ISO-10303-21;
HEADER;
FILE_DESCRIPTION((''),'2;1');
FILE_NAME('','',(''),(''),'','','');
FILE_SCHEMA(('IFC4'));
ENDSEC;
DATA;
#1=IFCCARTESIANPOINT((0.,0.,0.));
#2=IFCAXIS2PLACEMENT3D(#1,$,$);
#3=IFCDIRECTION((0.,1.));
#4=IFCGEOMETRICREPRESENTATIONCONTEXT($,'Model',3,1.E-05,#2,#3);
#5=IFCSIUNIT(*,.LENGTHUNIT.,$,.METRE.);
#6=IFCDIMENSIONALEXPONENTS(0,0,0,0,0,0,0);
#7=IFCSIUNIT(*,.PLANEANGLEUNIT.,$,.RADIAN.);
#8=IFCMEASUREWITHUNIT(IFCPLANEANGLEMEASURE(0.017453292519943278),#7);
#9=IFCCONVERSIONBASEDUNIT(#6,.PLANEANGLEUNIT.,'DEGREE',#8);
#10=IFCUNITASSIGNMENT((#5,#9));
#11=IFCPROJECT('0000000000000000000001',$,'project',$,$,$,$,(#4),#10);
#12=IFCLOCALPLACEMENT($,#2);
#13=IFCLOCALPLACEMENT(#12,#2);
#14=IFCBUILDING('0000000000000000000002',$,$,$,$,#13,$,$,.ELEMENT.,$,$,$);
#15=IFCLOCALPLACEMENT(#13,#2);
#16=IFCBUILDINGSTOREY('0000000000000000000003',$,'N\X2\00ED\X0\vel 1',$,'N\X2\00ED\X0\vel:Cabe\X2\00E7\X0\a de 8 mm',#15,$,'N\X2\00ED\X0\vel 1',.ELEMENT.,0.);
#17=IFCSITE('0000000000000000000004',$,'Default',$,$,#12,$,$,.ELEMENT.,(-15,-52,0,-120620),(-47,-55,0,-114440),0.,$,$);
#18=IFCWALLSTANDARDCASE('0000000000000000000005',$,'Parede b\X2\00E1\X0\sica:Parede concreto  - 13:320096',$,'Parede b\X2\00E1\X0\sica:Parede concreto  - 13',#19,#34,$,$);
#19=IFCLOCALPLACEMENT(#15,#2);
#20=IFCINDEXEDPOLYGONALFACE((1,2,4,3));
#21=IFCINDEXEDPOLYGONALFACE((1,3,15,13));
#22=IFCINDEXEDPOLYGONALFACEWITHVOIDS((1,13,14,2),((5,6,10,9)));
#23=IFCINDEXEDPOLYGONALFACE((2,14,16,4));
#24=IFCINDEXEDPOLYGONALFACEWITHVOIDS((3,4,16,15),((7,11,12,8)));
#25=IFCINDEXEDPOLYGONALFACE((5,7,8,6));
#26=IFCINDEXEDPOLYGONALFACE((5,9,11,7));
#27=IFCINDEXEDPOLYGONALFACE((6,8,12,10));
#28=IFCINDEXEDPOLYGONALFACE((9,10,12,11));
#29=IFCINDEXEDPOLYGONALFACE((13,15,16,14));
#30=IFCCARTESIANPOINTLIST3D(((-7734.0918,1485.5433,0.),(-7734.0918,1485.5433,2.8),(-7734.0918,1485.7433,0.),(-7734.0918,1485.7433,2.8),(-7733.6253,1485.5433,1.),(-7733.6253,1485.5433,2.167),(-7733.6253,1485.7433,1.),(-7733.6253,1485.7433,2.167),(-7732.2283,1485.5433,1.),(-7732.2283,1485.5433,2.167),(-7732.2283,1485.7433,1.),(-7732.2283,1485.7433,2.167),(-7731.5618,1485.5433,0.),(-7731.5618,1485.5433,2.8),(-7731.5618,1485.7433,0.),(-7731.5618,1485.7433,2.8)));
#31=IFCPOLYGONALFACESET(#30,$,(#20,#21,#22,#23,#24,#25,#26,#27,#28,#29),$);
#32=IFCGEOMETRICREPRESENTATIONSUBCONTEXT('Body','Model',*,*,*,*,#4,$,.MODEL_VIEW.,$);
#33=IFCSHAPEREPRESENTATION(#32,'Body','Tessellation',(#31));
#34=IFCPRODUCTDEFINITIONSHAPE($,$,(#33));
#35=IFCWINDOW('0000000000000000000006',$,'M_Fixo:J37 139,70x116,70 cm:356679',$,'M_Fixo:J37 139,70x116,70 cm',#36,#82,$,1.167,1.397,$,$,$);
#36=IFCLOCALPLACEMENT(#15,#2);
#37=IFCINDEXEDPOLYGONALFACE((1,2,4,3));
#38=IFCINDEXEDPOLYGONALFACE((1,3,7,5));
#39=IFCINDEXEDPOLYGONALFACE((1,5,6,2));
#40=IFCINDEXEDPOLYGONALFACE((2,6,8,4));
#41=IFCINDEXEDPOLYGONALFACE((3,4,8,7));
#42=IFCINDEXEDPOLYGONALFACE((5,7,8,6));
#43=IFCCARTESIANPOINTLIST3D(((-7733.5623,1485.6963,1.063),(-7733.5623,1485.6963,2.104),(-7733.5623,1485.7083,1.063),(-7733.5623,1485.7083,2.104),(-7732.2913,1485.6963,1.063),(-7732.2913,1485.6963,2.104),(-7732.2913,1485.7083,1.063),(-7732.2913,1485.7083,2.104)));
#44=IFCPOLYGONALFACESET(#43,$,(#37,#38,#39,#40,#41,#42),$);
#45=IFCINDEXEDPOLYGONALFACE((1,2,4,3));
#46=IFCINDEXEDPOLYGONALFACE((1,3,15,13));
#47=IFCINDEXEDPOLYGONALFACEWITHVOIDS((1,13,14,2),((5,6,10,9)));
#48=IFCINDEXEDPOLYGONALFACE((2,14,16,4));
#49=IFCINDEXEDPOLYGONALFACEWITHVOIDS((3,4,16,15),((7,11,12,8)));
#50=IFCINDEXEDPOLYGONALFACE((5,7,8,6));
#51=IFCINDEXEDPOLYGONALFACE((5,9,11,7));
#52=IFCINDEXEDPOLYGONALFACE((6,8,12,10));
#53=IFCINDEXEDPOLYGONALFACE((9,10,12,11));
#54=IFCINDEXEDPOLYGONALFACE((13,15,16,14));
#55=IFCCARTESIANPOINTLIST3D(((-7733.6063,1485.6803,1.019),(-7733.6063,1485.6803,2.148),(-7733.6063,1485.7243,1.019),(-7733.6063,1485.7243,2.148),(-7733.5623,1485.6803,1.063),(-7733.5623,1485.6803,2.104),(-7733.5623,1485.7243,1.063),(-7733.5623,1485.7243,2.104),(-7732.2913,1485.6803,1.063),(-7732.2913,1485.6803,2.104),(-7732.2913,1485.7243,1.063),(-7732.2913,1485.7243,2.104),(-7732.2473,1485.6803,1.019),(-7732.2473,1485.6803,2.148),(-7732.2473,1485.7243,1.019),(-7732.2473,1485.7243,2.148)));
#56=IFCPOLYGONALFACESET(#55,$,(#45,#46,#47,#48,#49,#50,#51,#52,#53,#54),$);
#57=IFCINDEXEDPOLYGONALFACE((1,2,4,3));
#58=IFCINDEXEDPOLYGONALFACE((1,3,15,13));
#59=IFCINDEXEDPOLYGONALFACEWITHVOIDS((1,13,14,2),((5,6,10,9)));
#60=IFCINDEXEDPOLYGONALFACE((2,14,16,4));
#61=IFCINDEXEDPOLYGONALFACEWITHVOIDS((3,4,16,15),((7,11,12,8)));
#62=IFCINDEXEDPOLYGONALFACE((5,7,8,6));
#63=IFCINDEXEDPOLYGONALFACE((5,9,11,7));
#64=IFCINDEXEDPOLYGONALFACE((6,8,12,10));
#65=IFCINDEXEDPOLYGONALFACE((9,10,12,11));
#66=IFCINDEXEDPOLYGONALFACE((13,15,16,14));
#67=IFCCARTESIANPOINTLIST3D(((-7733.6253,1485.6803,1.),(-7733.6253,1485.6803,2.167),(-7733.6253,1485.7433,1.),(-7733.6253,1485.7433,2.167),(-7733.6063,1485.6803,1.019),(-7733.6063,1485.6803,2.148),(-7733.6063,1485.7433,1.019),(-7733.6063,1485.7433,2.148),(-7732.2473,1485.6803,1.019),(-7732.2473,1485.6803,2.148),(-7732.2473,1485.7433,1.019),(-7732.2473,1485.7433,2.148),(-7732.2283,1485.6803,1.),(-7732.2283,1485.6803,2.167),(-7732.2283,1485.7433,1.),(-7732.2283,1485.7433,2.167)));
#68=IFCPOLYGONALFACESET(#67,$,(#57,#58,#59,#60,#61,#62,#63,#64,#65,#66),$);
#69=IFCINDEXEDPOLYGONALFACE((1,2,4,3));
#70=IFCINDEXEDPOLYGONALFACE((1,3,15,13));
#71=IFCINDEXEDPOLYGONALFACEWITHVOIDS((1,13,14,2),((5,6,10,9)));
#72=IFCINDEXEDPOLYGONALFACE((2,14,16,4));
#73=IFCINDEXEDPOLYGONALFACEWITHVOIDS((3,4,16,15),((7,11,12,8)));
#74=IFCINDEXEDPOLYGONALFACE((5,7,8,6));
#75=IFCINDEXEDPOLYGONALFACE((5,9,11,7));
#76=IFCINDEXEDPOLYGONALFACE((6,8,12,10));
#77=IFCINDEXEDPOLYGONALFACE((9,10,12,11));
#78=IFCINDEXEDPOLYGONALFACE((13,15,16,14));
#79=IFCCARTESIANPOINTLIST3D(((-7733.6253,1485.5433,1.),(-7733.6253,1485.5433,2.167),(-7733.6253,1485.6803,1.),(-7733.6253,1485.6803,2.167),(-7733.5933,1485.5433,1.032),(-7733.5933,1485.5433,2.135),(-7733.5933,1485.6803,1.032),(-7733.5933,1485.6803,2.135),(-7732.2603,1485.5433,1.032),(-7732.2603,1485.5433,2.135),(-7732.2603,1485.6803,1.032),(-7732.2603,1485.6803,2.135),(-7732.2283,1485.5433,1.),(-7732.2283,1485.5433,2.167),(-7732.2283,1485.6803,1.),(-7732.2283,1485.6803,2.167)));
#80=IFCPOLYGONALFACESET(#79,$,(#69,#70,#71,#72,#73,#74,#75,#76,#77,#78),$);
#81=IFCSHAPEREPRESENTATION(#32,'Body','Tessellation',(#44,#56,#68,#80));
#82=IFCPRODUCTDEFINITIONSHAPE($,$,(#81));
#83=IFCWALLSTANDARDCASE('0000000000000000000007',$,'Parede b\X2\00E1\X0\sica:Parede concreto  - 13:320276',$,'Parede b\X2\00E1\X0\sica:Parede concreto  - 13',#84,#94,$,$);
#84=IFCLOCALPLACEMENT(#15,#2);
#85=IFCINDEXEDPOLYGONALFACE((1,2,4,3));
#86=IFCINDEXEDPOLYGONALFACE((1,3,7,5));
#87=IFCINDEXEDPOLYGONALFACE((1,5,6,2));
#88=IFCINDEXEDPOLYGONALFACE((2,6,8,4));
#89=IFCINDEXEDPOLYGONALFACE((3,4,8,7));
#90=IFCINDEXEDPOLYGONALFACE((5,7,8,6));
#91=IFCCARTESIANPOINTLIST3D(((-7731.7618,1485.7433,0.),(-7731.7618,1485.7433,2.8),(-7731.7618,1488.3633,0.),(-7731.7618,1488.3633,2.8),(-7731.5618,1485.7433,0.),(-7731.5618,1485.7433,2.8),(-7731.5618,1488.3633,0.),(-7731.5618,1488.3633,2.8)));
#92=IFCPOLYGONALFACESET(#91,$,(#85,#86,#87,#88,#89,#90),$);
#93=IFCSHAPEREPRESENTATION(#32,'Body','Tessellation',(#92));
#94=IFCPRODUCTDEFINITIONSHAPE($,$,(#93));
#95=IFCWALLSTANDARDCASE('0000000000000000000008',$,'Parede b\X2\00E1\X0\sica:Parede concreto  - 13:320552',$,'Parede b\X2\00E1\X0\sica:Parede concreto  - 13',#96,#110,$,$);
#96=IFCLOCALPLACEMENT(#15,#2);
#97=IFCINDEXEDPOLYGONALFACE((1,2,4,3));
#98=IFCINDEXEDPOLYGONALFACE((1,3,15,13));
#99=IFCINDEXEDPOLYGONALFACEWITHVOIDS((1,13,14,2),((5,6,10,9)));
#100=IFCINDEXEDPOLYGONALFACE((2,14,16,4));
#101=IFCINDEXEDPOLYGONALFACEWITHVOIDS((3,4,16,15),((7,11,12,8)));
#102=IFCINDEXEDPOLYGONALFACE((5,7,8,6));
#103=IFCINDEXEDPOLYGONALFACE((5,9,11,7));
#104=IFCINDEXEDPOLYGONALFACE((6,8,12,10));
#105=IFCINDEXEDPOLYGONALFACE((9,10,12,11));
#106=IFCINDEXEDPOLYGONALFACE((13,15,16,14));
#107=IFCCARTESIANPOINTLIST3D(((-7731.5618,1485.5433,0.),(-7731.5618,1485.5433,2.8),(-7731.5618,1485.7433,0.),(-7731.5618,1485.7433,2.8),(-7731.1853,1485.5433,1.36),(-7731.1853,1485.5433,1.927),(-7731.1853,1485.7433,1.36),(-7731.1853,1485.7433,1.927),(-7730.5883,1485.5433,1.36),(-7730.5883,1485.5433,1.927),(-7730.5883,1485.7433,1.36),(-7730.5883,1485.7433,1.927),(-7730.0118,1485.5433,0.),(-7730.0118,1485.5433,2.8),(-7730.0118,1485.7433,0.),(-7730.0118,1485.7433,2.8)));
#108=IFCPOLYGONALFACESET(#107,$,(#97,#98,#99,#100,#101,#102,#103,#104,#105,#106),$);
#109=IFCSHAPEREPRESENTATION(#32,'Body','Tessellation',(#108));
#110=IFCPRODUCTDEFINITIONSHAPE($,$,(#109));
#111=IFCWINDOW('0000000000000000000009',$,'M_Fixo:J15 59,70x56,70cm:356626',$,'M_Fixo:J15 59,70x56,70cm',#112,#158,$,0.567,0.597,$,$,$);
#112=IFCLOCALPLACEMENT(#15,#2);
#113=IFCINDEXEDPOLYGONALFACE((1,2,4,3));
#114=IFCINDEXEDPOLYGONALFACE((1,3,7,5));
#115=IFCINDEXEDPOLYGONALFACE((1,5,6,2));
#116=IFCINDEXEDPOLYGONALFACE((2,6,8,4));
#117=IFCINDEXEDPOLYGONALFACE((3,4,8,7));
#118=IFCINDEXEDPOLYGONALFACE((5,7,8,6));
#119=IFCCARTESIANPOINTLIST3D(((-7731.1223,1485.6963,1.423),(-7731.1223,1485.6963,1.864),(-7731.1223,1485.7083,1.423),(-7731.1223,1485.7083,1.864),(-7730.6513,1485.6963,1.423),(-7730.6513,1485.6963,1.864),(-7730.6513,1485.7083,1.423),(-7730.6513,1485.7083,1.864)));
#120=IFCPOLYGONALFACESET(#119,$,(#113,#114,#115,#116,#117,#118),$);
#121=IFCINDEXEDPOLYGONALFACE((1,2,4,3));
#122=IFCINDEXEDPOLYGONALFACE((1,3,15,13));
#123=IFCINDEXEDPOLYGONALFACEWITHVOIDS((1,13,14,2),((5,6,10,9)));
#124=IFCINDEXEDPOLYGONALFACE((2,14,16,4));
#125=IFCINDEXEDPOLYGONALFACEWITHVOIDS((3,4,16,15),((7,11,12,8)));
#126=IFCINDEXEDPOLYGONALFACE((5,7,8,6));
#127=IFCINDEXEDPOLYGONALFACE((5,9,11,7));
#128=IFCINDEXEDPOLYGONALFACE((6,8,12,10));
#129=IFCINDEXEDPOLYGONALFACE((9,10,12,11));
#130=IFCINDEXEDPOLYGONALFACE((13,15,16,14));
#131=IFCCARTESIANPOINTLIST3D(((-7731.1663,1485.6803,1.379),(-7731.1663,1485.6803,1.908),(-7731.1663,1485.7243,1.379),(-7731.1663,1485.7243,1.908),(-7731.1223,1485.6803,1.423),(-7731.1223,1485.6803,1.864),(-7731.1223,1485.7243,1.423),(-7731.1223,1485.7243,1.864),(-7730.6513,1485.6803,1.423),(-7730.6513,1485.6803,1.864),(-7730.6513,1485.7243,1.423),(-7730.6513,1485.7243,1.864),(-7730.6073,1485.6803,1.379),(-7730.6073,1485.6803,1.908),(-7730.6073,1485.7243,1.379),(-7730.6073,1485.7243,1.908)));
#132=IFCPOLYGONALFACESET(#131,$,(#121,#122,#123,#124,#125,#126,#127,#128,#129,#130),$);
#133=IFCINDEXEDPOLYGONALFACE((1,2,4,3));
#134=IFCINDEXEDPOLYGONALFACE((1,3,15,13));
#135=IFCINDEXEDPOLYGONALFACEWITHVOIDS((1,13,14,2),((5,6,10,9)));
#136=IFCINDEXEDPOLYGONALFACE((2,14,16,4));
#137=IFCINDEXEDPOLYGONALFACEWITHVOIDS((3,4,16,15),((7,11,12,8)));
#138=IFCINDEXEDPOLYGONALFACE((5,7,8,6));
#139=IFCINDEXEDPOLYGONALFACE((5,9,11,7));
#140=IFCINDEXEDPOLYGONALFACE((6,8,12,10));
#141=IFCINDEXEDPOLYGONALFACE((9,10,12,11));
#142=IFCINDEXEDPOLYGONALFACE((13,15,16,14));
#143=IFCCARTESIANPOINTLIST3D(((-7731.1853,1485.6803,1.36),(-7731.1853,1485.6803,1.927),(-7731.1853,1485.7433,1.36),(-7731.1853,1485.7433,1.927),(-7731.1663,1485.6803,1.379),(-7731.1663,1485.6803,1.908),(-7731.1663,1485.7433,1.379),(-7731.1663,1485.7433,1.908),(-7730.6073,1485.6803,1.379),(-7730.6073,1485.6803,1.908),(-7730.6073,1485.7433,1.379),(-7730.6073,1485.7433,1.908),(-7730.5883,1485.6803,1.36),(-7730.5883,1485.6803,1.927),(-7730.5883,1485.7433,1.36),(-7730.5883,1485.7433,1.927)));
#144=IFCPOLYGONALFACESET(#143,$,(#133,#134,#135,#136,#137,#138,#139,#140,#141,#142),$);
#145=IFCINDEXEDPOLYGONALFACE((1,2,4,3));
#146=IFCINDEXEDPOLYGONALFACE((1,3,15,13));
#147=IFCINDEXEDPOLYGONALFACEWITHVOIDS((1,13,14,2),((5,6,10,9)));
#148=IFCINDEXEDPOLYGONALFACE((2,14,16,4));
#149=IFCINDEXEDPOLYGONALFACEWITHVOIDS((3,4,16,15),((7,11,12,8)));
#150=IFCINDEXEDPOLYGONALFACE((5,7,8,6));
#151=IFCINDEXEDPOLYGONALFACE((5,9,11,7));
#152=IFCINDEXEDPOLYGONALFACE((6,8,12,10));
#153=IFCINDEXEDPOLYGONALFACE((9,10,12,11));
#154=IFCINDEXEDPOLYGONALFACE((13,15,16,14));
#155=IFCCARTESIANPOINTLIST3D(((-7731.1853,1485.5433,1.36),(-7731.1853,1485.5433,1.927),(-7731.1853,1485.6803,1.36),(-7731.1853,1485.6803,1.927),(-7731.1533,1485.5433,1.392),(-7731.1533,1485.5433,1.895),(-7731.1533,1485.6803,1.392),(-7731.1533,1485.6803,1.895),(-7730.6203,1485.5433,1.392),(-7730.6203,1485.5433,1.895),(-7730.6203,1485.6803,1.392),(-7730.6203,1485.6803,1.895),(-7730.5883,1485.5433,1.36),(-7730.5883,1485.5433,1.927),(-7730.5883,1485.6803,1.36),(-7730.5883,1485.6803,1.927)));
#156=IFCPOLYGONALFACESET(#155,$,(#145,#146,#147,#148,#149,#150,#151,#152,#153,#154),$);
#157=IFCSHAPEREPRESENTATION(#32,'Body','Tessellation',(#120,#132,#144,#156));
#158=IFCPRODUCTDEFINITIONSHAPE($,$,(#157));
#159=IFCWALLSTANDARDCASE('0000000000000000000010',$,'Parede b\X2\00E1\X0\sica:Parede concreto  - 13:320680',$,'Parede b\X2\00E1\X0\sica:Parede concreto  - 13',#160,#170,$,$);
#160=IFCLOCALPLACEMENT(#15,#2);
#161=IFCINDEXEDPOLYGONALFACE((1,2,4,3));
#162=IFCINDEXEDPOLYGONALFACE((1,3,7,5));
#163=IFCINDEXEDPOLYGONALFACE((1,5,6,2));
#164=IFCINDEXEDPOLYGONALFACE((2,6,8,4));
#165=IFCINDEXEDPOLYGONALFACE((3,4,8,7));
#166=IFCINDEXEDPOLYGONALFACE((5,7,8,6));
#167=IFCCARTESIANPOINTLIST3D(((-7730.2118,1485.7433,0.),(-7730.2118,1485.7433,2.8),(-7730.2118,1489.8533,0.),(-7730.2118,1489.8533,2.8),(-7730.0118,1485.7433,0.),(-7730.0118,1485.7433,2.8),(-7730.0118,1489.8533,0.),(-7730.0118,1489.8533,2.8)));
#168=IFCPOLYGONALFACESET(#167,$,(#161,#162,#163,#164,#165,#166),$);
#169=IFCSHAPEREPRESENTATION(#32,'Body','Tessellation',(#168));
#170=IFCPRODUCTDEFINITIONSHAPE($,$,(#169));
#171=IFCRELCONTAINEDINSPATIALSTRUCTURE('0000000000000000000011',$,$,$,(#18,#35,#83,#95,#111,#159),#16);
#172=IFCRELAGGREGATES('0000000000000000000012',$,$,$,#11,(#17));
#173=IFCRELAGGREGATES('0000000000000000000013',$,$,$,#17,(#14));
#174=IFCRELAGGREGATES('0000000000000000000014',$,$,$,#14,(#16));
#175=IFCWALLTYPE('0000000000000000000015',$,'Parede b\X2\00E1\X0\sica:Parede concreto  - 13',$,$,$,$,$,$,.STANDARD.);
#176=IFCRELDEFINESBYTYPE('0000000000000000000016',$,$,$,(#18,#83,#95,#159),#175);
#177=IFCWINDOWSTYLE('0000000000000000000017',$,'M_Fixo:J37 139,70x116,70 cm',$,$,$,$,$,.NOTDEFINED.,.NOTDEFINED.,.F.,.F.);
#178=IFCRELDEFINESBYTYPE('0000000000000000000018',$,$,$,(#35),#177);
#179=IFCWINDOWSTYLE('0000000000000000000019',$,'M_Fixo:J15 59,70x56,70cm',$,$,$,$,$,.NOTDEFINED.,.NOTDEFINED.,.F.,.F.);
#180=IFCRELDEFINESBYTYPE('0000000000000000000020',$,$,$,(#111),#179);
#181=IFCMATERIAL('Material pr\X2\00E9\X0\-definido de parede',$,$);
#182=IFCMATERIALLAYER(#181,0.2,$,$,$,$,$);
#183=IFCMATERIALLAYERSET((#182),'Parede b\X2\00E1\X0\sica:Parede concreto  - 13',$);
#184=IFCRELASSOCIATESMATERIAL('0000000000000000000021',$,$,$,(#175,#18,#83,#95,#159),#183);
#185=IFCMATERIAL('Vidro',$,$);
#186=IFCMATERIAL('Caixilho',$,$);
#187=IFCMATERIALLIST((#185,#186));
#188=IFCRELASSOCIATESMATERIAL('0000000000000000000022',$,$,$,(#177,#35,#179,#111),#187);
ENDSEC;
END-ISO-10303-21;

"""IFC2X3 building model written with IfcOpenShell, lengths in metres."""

from ifc_helpers import new_model, entity, si_unit, converted_unit, direction, frame, frame_2d, origin, place, context, subcontext, project, spatial, polyline, rectangle, outline, extrude, source, transform, mapped, material, material_list, layer, layer_set, layer_usage, type_object, type_shapes, element, fill, save


model = new_model("IFC2X3")

# Units and contexts
model_context = context("Model", 3, precision=1e-05, world=origin(), true_north=direction((0.0, 1.0)))
body_context = subcontext(model_context, "Body", "Model", "MODEL_VIEW")
ifc_project = project(units=[si_unit("LENGTHUNIT", "METRE"), converted_unit("PLANEANGLEUNIT", "DEGREE", entity("IfcPlaneAngleMeasure", 0.017453292519943278), si_unit("PLANEANGLEUNIT", "RADIAN"), dimensions=[0, 0, 0, 0, 0, 0, 0])], contexts=[model_context])

# Site, building, storey
site_placement = place(None, origin())
site = spatial("IfcSite", under=ifc_project, at=site_placement, Name="Default", CompositionType="ELEMENT", RefLatitude=(-15, -52, 0, -120620), RefLongitude=(-47, -55, 0, -114440), RefElevation=0.0)
building_placement = place(site_placement, origin())
building = spatial("IfcBuilding", under=site, at=building_placement, CompositionType="ELEMENT")
storey_placement = place(building_placement, origin())
storey = spatial("IfcBuildingStorey", under=building, at=storey_placement, Name="Nível 1", ObjectType="Nível:Cabeça de 8 mm", LongName="Nível 1", CompositionType="ELEMENT", Elevation=0.0)

# Wall, opening, window
ifc_material_1 = material(Name="Material pré-definido de parede")
ifc_layer_1 = layer(ifc_material_1, 0.2)
ifc_layer_set_1 = layer_set([ifc_layer_1], Name="Parede básica:Parede concreto  - 13")
ifc_layer_usage_1 = layer_usage(ifc_layer_set_1, "AXIS2", "NEGATIVE", 0.1)
wall_type_1 = type_object("IfcWallType", Name="Parede básica:Parede concreto  - 13", PredefinedType="STANDARD", material=ifc_layer_set_1)
wall_1_placement = place(storey_placement, frame((-7734.0918, 1485.6433, 0.0)))
wall_1 = element("IfcWallStandardCase", 1, at=wall_1_placement, inside=storey, type_object=wall_type_1, material=ifc_layer_usage_1, Name="Parede básica:Parede concreto  - 13:320096", ObjectType="Parede básica:Parede concreto  - 13", context=body_context, shape_type="SweptSolid", body=[
    extrude(rectangle(XDim=2.53, YDim=0.2, at=frame_2d((1.265, 0.0), x_axis=(-1.0, 0.0))), origin(), (0.0, 0.0, 1.0), 2.8),
])
opening_1_placement = place(wall_1_placement, frame((0.4665, -0.1, 1.0)))
opening_1 = element("IfcOpeningElement", 2, at=opening_1_placement, cuts=wall_1, ObjectType="Opening", context=body_context, shape_type="SweptSolid", body=[
    extrude(rectangle(XDim=1.167, YDim=1.397, at=frame_2d((0.5835, 0.6985), x_axis=(1.0, 0.0))), frame((0.0, 0.0, 0.0), z_axis=(0.0, 1.0, 0.0), x_axis=(0.0, 0.0, 1.0)), (0.0, 0.0, 1.0), 0.2),
])
ifc_material_2 = material(Name="Vidro")
ifc_material_3 = material(Name="Caixilho")
ifc_material_list = material_list([ifc_material_2, ifc_material_3])
window_style_1 = type_object("IfcWindowStyle", Name="M_Fixo:J37 139,70x116,70 cm", ConstructionType="NOTDEFINED", OperationType="NOTDEFINED", ParameterTakesPrecedence=False, Sizeable=False, material=ifc_material_list)
shared_shape_1 = source(origin(), body_context, "Body", "SweptSolid", [
    extrude(rectangle(XDim=0.012, YDim=1.271, at=frame_2d((0.0, 0.0), x_axis=(1.0, 0.0))), frame((0.6985, 0.159, 0.063), z_axis=(0.0, 0.0, 1.0), x_axis=(0.0, -1.0, 0.0)), (0.0, 0.0, 1.0), 1.041),
    extrude(outline(polyline([(-0.6795, -0.5645), (0.6795, -0.5645), (0.6795, 0.5645), (-0.6795, 0.5645), (-0.6795, -0.5645)]), holes=[polyline([(-0.6355, -0.5205), (-0.6355, 0.5205), (0.6355, 0.5205), (0.6355, -0.5205), (-0.6355, -0.5205)])]), frame((0.6985, 0.137, 0.5835), z_axis=(0.0, 1.0, 0.0), x_axis=(1.0, 0.0, 0.0)), (0.0, 0.0, 1.0), 0.044),
    extrude(outline(polyline([(-0.6985, -0.5835), (0.6985, -0.5835), (0.6985, 0.5835), (-0.6985, 0.5835), (-0.6985, -0.5835)]), holes=[polyline([(-0.6795, -0.5645), (-0.6795, 0.5645), (0.6795, 0.5645), (0.6795, -0.5645), (-0.6795, -0.5645)])]), frame((0.6985, 0.137, 0.5835), z_axis=(0.0, 1.0, 0.0), x_axis=(1.0, 0.0, 0.0)), (0.0, 0.0, 1.0), 0.063),
    extrude(outline(polyline([(-0.6985, -0.5835), (0.6985, -0.5835), (0.6985, 0.5835), (-0.6985, 0.5835), (-0.6985, -0.5835)]), holes=[polyline([(-0.6665, -0.5515), (-0.6665, 0.5515), (0.6665, 0.5515), (0.6665, -0.5515), (-0.6665, -0.5515)])]), frame((0.6985, 0.0, 0.5835), z_axis=(0.0, 1.0, 0.0), x_axis=(1.0, 0.0, 0.0)), (0.0, 0.0, 1.0), 0.137),
])
type_shapes(window_style_1, [shared_shape_1])
window_1_placement = place(opening_1_placement, origin())
window_1 = element("IfcWindow", 3, at=window_1_placement, inside=storey, type_object=window_style_1, material=ifc_material_list, Name="M_Fixo:J37 139,70x116,70 cm:356679", ObjectType="M_Fixo:J37 139,70x116,70 cm", OverallHeight=1.167, OverallWidth=1.397, context=body_context, shape_type="MappedRepresentation", body=[
    mapped(shared_shape_1, transform((0.0, 0.0, 0.0), scale=1.0)),
])
fill(opening_1, window_1)

# Wall
ifc_layer_usage_2 = layer_usage(ifc_layer_set_1, "AXIS2", "NEGATIVE", 0.1)
wall_2_placement = place(storey_placement, frame((-7731.6618, 1485.7433, 0.0), z_axis=(0.0, 0.0, 1.0), x_axis=(0.0, 1.0, 0.0)))
element("IfcWallStandardCase", 4, at=wall_2_placement, inside=storey, type_object=wall_type_1, material=ifc_layer_usage_2, Name="Parede básica:Parede concreto  - 13:320276", ObjectType="Parede básica:Parede concreto  - 13", context=body_context, shape_type="SweptSolid", body=[
    extrude(rectangle(XDim=2.62, YDim=0.2, at=frame_2d((1.31, 0.0), x_axis=(-1.0, 0.0))), origin(), (0.0, 0.0, 1.0), 2.8),
])

# Wall, opening, window
ifc_layer_usage_3 = layer_usage(ifc_layer_set_1, "AXIS2", "POSITIVE", -0.1)
wall_3_placement = place(storey_placement, frame((-7730.0118, 1485.6433, 0.0), z_axis=(0.0, 0.0, 1.0), x_axis=(-1.0, 0.0, 0.0)))
wall_3 = element("IfcWallStandardCase", 5, at=wall_3_placement, inside=storey, type_object=wall_type_1, material=ifc_layer_usage_3, Name="Parede básica:Parede concreto  - 13:320552", ObjectType="Parede básica:Parede concreto  - 13", context=body_context, shape_type="SweptSolid", body=[
    extrude(rectangle(XDim=1.55, YDim=0.2, at=frame_2d((0.775, 0.0), x_axis=(-1.0, 0.0))), origin(), (0.0, 0.0, 1.0), 2.8),
])
opening_2_placement = place(wall_3_placement, frame((1.1735, 0.1, 1.36)))
opening_2 = element("IfcOpeningElement", 6, at=opening_2_placement, cuts=wall_3, ObjectType="Opening", context=body_context, shape_type="SweptSolid", body=[
    extrude(rectangle(XDim=0.567, YDim=0.597, at=frame_2d((0.2835, 0.2985), x_axis=(1.0, 0.0))), frame((0.0, 0.0, 0.0), z_axis=(0.0, -1.0, 0.0), x_axis=(0.0, 0.0, 1.0)), (0.0, 0.0, 1.0), 0.2),
])
window_style_2 = type_object("IfcWindowStyle", Name="M_Fixo:J15 59,70x56,70cm", ConstructionType="NOTDEFINED", OperationType="NOTDEFINED", ParameterTakesPrecedence=False, Sizeable=False, material=ifc_material_list)
shared_shape_2 = source(origin(), body_context, "Body", "SweptSolid", [
    extrude(rectangle(XDim=0.012, YDim=0.471, at=frame_2d((0.0, 0.0), x_axis=(1.0, 0.0))), frame((0.2985, 0.159, 0.063), z_axis=(0.0, 0.0, 1.0), x_axis=(0.0, -1.0, 0.0)), (0.0, 0.0, 1.0), 0.441),
    extrude(outline(polyline([(-0.2795, -0.2645), (0.2795, -0.2645), (0.2795, 0.2645), (-0.2795, 0.2645), (-0.2795, -0.2645)]), holes=[polyline([(-0.2355, -0.2205), (-0.2355, 0.2205), (0.2355, 0.2205), (0.2355, -0.2205), (-0.2355, -0.2205)])]), frame((0.2985, 0.137, 0.2835), z_axis=(0.0, 1.0, 0.0), x_axis=(1.0, 0.0, 0.0)), (0.0, 0.0, 1.0), 0.044),
    extrude(outline(polyline([(-0.2985, -0.2835), (0.2985, -0.2835), (0.2985, 0.2835), (-0.2985, 0.2835), (-0.2985, -0.2835)]), holes=[polyline([(-0.2795, -0.2645), (-0.2795, 0.2645), (0.2795, 0.2645), (0.2795, -0.2645), (-0.2795, -0.2645)])]), frame((0.2985, 0.137, 0.2835), z_axis=(0.0, 1.0, 0.0), x_axis=(1.0, 0.0, 0.0)), (0.0, 0.0, 1.0), 0.063),
    extrude(outline(polyline([(-0.2985, -0.2835), (0.2985, -0.2835), (0.2985, 0.2835), (-0.2985, 0.2835), (-0.2985, -0.2835)]), holes=[polyline([(-0.2665, -0.2515), (-0.2665, 0.2515), (0.2665, 0.2515), (0.2665, -0.2515), (-0.2665, -0.2515)])]), frame((0.2985, 0.0, 0.2835), z_axis=(0.0, 1.0, 0.0), x_axis=(1.0, 0.0, 0.0)), (0.0, 0.0, 1.0), 0.137),
])
type_shapes(window_style_2, [shared_shape_2])
window_2_placement = place(opening_2_placement, frame((0.0, 0.0, 0.0), z_axis=(0.0, 0.0, 1.0), x_axis=(-1.0, 0.0, 0.0)))
window_2 = element("IfcWindow", 7, at=window_2_placement, inside=storey, type_object=window_style_2, material=ifc_material_list, Name="M_Fixo:J15 59,70x56,70cm:356626", ObjectType="M_Fixo:J15 59,70x56,70cm", OverallHeight=0.567, OverallWidth=0.597, context=body_context, shape_type="MappedRepresentation", body=[
    mapped(shared_shape_2, transform((0.0, 0.0, 0.0), scale=1.0)),
])
fill(opening_2, window_2)

# Wall
ifc_layer_usage_4 = layer_usage(ifc_layer_set_1, "AXIS2", "POSITIVE", -0.1)
wall_4_placement = place(storey_placement, frame((-7730.1118, 1489.8533, 0.0), z_axis=(0.0, 0.0, 1.0), x_axis=(0.0, -1.0, 0.0)))
element("IfcWallStandardCase", 8, at=wall_4_placement, inside=storey, type_object=wall_type_1, material=ifc_layer_usage_4, Name="Parede básica:Parede concreto  - 13:320680", ObjectType="Parede básica:Parede concreto  - 13", context=body_context, shape_type="SweptSolid", body=[
    extrude(rectangle(XDim=4.11, YDim=0.2, at=frame_2d((2.055, 0.0), x_axis=(-1.0, 0.0))), origin(), (0.0, 0.0, 1.0), 2.8),
])

save(model, "model.ifc")
